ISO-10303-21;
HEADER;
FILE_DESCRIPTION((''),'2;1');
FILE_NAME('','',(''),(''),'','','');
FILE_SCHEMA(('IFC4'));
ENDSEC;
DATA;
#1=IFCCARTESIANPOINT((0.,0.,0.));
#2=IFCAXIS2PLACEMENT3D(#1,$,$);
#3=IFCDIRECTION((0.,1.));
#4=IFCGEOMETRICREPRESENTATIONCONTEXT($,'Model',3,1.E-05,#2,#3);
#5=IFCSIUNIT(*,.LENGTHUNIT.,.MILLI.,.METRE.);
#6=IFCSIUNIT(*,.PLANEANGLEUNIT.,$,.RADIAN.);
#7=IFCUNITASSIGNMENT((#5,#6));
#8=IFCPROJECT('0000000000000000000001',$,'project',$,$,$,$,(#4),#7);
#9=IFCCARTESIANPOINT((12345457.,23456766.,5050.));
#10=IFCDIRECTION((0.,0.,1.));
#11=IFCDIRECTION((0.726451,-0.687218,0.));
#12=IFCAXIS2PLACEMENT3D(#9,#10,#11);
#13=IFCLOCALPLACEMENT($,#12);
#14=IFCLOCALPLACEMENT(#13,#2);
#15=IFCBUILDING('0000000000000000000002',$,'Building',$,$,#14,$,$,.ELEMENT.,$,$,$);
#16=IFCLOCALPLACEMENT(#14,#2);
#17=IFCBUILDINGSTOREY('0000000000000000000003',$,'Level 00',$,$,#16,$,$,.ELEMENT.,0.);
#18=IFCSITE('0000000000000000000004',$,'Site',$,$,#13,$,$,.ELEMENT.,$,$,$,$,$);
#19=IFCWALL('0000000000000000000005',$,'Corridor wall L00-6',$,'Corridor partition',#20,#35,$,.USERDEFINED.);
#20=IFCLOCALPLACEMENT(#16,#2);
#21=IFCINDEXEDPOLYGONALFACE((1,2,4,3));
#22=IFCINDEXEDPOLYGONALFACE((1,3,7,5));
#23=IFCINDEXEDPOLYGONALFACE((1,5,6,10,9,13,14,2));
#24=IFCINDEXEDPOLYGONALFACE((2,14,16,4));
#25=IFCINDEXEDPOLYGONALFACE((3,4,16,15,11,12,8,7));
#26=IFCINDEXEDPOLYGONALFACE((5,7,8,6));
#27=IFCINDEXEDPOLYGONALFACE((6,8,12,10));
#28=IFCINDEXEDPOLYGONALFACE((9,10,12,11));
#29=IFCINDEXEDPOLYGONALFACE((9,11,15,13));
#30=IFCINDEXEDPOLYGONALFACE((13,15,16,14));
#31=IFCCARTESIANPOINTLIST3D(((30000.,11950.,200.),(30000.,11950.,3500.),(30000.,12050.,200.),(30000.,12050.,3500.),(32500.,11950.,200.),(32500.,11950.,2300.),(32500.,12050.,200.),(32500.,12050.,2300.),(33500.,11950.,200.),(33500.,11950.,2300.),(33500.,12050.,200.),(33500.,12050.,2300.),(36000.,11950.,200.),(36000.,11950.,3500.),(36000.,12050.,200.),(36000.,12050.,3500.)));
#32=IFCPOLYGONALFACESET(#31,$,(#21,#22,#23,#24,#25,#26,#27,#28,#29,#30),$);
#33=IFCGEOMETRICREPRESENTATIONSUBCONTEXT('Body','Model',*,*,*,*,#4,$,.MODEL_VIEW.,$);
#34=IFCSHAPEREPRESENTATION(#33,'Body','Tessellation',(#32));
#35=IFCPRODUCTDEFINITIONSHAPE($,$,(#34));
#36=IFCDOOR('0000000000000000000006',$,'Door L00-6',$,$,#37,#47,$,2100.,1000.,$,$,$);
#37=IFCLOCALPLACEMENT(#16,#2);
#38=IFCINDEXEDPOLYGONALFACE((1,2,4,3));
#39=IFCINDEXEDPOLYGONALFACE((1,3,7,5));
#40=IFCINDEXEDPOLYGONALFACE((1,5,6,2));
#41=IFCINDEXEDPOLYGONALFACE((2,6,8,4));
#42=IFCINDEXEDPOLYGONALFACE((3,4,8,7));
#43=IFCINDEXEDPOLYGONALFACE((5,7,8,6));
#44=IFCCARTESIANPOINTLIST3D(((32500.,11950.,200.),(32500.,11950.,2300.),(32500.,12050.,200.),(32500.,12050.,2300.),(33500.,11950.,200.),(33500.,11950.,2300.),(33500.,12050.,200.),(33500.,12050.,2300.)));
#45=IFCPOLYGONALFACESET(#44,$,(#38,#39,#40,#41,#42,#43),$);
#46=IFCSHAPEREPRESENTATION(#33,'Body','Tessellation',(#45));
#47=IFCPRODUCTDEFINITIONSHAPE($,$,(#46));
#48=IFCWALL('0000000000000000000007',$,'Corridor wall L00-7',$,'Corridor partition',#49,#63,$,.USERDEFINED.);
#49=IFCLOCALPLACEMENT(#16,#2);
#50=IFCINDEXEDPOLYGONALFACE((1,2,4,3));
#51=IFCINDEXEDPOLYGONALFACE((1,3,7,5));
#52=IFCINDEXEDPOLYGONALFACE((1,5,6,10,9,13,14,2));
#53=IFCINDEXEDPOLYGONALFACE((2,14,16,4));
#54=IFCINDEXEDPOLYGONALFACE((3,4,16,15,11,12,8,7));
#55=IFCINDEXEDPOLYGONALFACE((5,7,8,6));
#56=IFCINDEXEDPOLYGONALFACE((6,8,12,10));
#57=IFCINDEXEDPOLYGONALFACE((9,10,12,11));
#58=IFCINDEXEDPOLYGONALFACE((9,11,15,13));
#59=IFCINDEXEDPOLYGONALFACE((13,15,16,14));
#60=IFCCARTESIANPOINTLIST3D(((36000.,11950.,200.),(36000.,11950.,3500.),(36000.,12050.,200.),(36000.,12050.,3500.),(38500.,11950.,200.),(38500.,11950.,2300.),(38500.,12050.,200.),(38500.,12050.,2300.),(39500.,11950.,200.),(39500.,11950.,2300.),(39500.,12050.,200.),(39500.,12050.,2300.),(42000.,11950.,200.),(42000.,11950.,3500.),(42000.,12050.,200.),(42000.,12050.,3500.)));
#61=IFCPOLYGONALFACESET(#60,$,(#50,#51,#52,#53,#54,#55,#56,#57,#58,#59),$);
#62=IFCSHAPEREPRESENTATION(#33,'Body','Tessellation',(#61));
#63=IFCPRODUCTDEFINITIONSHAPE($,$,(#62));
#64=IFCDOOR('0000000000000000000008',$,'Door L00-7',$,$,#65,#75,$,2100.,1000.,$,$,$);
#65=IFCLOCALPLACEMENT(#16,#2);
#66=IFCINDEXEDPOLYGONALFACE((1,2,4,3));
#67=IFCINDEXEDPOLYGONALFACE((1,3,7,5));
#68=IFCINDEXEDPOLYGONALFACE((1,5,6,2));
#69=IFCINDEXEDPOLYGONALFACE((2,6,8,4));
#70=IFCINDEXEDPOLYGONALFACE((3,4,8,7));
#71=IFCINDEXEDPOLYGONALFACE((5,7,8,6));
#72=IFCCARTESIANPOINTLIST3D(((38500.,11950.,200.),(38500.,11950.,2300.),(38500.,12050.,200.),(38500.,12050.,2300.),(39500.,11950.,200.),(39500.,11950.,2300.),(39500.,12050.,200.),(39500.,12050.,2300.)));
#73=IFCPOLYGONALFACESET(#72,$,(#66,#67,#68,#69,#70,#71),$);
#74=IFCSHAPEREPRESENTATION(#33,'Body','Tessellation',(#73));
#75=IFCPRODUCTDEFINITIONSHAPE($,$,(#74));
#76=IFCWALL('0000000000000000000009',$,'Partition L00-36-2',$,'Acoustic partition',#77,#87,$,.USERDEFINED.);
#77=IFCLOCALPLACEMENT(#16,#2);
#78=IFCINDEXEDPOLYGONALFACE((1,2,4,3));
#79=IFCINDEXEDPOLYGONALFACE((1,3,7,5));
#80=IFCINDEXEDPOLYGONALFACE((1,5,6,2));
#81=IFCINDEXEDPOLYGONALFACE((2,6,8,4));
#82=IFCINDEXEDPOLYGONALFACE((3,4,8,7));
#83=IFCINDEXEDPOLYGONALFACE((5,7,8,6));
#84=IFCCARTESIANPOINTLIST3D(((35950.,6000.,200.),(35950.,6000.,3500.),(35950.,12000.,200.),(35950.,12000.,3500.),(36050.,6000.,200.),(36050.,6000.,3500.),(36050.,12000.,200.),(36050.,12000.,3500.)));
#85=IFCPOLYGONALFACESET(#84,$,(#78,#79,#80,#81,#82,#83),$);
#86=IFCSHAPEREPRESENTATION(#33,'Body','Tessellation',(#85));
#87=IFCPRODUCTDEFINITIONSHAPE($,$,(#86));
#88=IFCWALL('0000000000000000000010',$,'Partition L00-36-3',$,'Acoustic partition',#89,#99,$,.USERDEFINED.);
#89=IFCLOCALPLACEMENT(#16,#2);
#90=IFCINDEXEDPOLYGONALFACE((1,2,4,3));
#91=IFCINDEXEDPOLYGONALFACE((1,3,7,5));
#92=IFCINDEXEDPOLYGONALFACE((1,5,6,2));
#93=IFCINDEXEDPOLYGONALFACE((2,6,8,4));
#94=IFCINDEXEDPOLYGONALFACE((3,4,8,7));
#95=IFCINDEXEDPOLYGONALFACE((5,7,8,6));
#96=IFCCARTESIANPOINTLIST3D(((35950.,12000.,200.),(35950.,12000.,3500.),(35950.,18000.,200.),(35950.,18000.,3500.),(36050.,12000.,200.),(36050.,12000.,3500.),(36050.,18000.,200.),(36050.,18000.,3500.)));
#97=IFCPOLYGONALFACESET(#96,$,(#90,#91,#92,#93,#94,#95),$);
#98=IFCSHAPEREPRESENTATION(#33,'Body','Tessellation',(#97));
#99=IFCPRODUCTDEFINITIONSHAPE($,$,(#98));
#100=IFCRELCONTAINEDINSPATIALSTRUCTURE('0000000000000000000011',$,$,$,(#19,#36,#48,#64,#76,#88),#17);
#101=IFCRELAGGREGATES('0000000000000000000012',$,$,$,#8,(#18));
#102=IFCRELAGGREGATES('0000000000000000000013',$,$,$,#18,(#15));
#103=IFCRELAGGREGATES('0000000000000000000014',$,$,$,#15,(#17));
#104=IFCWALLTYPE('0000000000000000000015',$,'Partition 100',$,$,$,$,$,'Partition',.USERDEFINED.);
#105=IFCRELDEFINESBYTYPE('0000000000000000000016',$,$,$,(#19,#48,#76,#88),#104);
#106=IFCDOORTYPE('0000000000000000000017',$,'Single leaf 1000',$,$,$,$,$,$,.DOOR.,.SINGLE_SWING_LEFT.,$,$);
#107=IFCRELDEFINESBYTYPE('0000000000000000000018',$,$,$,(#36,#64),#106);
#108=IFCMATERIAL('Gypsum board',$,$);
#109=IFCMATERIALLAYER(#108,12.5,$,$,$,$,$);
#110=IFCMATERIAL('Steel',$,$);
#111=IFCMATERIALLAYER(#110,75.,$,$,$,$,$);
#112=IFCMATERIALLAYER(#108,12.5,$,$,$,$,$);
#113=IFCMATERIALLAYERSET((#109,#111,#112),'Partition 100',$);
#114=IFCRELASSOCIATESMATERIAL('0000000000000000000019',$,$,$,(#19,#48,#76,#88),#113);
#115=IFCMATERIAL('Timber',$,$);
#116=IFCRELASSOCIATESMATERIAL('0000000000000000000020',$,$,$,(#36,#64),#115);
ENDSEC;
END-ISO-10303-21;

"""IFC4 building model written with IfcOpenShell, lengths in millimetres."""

from ifc_helpers import new_model, si_unit, direction, frame, origin, place, context, subcontext, project, spatial, rectangle, extrude, source, transform, mapped, material, layer, layer_set, layer_usage, type_object, type_shapes, element, fill, save


model = new_model("IFC4")

# Units and contexts
model_context = context("Model", 3, precision=1e-05, world=origin(), true_north=direction((0.0, 1.0)))
body_context = subcontext(model_context, "Body", "Model", "MODEL_VIEW")
ifc_project = project(units=[si_unit("LENGTHUNIT", "METRE", prefix="MILLI"), si_unit("PLANEANGLEUNIT", "RADIAN")], contexts=[model_context])

# Site, building, storey
site_placement = place(None, frame((12345457.0, 23456766.0, 5050.0), z_axis=(0.0, 0.0, 1.0), x_axis=(0.726451, -0.687218, 0.0)))
site = spatial("IfcSite", under=ifc_project, at=site_placement, Name="Site", CompositionType="ELEMENT")
building_placement = place(site_placement, origin())
building = spatial("IfcBuilding", under=site, at=building_placement, Name="Building", CompositionType="ELEMENT")
storey_placement = place(building_placement, origin())
storey = spatial("IfcBuildingStorey", under=building, at=storey_placement, Name="Level 00", CompositionType="ELEMENT", Elevation=0.0)

# Shared definitions
ifc_material_1 = material(Name="Steel")

# Walls, openings, doors
ifc_material_2 = material(Name="Gypsum board")
ifc_layer_1 = layer(ifc_material_2, 12.5)
ifc_layer_2 = layer(ifc_material_1, 75.0)
ifc_layer_3 = layer(ifc_material_2, 12.5)
ifc_layer_set_1 = layer_set([ifc_layer_1, ifc_layer_2, ifc_layer_3], Name="Partition 100")
ifc_layer_usage_1 = layer_usage(ifc_layer_set_1, "AXIS2", "POSITIVE", 0.0)
wall_type_1 = type_object("IfcWallType", Name="Partition 100", ElementType="Partition", PredefinedType="USERDEFINED")
wall_1_placement = place(storey_placement, frame((30000.0, 11950.0, 200.0)))
wall_1 = element("IfcWall", 1, at=wall_1_placement, inside=storey, type_object=wall_type_1, material=ifc_layer_usage_1, Name="Corridor wall L00-6", ObjectType="Corridor partition", PredefinedType="USERDEFINED", context=body_context, shape_type="SweptSolid", body=[
    extrude(rectangle(XDim=6000.0, YDim=100.0), frame((3000.0, 50.0, 0.0)), (0.0, 0.0, 1.0), 3300.0),
])
opening_1_placement = place(wall_1_placement, frame((2500.0, -50.0, 0.0)))
opening_1 = element("IfcOpeningElement", 2, at=opening_1_placement, cuts=wall_1, PredefinedType="OPENING", context=body_context, shape_type="SweptSolid", body=[
    extrude(rectangle(XDim=1000.0, YDim=200.0), frame((500.0, 100.0, 0.0)), (0.0, 0.0, 1.0), 2100.0),
])
ifc_material_3 = material(Name="Timber")
door_type = type_object("IfcDoorType", Name="Single leaf 1000", OperationType="SINGLE_SWING_LEFT", PredefinedType="DOOR")
shared_shape = source(origin(), body_context, "Body", "SweptSolid", [
    extrude(rectangle(XDim=1000.0, YDim=100.0), frame((500.0, 50.0, 0.0)), (0.0, 0.0, 1.0), 2100.0),
])
type_shapes(door_type, [shared_shape])
door_1_placement = place(storey_placement, frame((32500.0, 11950.0, 200.0)))
door_1 = element("IfcDoor", 3, at=door_1_placement, inside=storey, type_object=door_type, material=ifc_material_3, Name="Door L00-6", OverallHeight=2100.0, OverallWidth=1000.0, context=body_context, shape_type="MappedRepresentation", body=[
    mapped(shared_shape, transform((0.0, 0.0, 0.0))),
])
fill(opening_1, door_1)
wall_2_placement = place(storey_placement, frame((36000.0, 11950.0, 200.0)))
wall_2 = element("IfcWall", 4, at=wall_2_placement, inside=storey, type_object=wall_type_1, material=ifc_layer_usage_1, Name="Corridor wall L00-7", ObjectType="Corridor partition", PredefinedType="USERDEFINED", context=body_context, shape_type="SweptSolid", body=[
    extrude(rectangle(XDim=6000.0, YDim=100.0), frame((3000.0, 50.0, 0.0)), (0.0, 0.0, 1.0), 3300.0),
])
opening_2_placement = place(wall_2_placement, frame((2500.0, -50.0, 0.0)))
opening_2 = element("IfcOpeningElement", 5, at=opening_2_placement, cuts=wall_2, PredefinedType="OPENING", context=body_context, shape_type="SweptSolid", body=[
    extrude(rectangle(XDim=1000.0, YDim=200.0), frame((500.0, 100.0, 0.0)), (0.0, 0.0, 1.0), 2100.0),
])
door_2_placement = place(storey_placement, frame((38500.0, 11950.0, 200.0)))
door_2 = element("IfcDoor", 6, at=door_2_placement, inside=storey, type_object=door_type, material=ifc_material_3, Name="Door L00-7", OverallHeight=2100.0, OverallWidth=1000.0, context=body_context, shape_type="MappedRepresentation", body=[
    mapped(shared_shape, transform((0.0, 0.0, 0.0))),
])
fill(opening_2, door_2)

# Walls
for number, where, name in (
    (7, (35950.0, 6000.0, 200.0), "Partition L00-36-2"),
    (8, (35950.0, 12000.0, 200.0), "Partition L00-36-3"),
):
    element("IfcWall", number, at=place(storey_placement, frame(where)), inside=storey, type_object=wall_type_1, material=ifc_layer_usage_1, Name=name, ObjectType="Acoustic partition", PredefinedType="USERDEFINED", context=body_context, shape_type="SweptSolid", body=[
        extrude(rectangle(XDim=100.0, YDim=6000.0), frame((50.0, 3000.0, 0.0)), (0.0, 0.0, 1.0), 3300.0),
    ])

save(model, "model.ifc")
